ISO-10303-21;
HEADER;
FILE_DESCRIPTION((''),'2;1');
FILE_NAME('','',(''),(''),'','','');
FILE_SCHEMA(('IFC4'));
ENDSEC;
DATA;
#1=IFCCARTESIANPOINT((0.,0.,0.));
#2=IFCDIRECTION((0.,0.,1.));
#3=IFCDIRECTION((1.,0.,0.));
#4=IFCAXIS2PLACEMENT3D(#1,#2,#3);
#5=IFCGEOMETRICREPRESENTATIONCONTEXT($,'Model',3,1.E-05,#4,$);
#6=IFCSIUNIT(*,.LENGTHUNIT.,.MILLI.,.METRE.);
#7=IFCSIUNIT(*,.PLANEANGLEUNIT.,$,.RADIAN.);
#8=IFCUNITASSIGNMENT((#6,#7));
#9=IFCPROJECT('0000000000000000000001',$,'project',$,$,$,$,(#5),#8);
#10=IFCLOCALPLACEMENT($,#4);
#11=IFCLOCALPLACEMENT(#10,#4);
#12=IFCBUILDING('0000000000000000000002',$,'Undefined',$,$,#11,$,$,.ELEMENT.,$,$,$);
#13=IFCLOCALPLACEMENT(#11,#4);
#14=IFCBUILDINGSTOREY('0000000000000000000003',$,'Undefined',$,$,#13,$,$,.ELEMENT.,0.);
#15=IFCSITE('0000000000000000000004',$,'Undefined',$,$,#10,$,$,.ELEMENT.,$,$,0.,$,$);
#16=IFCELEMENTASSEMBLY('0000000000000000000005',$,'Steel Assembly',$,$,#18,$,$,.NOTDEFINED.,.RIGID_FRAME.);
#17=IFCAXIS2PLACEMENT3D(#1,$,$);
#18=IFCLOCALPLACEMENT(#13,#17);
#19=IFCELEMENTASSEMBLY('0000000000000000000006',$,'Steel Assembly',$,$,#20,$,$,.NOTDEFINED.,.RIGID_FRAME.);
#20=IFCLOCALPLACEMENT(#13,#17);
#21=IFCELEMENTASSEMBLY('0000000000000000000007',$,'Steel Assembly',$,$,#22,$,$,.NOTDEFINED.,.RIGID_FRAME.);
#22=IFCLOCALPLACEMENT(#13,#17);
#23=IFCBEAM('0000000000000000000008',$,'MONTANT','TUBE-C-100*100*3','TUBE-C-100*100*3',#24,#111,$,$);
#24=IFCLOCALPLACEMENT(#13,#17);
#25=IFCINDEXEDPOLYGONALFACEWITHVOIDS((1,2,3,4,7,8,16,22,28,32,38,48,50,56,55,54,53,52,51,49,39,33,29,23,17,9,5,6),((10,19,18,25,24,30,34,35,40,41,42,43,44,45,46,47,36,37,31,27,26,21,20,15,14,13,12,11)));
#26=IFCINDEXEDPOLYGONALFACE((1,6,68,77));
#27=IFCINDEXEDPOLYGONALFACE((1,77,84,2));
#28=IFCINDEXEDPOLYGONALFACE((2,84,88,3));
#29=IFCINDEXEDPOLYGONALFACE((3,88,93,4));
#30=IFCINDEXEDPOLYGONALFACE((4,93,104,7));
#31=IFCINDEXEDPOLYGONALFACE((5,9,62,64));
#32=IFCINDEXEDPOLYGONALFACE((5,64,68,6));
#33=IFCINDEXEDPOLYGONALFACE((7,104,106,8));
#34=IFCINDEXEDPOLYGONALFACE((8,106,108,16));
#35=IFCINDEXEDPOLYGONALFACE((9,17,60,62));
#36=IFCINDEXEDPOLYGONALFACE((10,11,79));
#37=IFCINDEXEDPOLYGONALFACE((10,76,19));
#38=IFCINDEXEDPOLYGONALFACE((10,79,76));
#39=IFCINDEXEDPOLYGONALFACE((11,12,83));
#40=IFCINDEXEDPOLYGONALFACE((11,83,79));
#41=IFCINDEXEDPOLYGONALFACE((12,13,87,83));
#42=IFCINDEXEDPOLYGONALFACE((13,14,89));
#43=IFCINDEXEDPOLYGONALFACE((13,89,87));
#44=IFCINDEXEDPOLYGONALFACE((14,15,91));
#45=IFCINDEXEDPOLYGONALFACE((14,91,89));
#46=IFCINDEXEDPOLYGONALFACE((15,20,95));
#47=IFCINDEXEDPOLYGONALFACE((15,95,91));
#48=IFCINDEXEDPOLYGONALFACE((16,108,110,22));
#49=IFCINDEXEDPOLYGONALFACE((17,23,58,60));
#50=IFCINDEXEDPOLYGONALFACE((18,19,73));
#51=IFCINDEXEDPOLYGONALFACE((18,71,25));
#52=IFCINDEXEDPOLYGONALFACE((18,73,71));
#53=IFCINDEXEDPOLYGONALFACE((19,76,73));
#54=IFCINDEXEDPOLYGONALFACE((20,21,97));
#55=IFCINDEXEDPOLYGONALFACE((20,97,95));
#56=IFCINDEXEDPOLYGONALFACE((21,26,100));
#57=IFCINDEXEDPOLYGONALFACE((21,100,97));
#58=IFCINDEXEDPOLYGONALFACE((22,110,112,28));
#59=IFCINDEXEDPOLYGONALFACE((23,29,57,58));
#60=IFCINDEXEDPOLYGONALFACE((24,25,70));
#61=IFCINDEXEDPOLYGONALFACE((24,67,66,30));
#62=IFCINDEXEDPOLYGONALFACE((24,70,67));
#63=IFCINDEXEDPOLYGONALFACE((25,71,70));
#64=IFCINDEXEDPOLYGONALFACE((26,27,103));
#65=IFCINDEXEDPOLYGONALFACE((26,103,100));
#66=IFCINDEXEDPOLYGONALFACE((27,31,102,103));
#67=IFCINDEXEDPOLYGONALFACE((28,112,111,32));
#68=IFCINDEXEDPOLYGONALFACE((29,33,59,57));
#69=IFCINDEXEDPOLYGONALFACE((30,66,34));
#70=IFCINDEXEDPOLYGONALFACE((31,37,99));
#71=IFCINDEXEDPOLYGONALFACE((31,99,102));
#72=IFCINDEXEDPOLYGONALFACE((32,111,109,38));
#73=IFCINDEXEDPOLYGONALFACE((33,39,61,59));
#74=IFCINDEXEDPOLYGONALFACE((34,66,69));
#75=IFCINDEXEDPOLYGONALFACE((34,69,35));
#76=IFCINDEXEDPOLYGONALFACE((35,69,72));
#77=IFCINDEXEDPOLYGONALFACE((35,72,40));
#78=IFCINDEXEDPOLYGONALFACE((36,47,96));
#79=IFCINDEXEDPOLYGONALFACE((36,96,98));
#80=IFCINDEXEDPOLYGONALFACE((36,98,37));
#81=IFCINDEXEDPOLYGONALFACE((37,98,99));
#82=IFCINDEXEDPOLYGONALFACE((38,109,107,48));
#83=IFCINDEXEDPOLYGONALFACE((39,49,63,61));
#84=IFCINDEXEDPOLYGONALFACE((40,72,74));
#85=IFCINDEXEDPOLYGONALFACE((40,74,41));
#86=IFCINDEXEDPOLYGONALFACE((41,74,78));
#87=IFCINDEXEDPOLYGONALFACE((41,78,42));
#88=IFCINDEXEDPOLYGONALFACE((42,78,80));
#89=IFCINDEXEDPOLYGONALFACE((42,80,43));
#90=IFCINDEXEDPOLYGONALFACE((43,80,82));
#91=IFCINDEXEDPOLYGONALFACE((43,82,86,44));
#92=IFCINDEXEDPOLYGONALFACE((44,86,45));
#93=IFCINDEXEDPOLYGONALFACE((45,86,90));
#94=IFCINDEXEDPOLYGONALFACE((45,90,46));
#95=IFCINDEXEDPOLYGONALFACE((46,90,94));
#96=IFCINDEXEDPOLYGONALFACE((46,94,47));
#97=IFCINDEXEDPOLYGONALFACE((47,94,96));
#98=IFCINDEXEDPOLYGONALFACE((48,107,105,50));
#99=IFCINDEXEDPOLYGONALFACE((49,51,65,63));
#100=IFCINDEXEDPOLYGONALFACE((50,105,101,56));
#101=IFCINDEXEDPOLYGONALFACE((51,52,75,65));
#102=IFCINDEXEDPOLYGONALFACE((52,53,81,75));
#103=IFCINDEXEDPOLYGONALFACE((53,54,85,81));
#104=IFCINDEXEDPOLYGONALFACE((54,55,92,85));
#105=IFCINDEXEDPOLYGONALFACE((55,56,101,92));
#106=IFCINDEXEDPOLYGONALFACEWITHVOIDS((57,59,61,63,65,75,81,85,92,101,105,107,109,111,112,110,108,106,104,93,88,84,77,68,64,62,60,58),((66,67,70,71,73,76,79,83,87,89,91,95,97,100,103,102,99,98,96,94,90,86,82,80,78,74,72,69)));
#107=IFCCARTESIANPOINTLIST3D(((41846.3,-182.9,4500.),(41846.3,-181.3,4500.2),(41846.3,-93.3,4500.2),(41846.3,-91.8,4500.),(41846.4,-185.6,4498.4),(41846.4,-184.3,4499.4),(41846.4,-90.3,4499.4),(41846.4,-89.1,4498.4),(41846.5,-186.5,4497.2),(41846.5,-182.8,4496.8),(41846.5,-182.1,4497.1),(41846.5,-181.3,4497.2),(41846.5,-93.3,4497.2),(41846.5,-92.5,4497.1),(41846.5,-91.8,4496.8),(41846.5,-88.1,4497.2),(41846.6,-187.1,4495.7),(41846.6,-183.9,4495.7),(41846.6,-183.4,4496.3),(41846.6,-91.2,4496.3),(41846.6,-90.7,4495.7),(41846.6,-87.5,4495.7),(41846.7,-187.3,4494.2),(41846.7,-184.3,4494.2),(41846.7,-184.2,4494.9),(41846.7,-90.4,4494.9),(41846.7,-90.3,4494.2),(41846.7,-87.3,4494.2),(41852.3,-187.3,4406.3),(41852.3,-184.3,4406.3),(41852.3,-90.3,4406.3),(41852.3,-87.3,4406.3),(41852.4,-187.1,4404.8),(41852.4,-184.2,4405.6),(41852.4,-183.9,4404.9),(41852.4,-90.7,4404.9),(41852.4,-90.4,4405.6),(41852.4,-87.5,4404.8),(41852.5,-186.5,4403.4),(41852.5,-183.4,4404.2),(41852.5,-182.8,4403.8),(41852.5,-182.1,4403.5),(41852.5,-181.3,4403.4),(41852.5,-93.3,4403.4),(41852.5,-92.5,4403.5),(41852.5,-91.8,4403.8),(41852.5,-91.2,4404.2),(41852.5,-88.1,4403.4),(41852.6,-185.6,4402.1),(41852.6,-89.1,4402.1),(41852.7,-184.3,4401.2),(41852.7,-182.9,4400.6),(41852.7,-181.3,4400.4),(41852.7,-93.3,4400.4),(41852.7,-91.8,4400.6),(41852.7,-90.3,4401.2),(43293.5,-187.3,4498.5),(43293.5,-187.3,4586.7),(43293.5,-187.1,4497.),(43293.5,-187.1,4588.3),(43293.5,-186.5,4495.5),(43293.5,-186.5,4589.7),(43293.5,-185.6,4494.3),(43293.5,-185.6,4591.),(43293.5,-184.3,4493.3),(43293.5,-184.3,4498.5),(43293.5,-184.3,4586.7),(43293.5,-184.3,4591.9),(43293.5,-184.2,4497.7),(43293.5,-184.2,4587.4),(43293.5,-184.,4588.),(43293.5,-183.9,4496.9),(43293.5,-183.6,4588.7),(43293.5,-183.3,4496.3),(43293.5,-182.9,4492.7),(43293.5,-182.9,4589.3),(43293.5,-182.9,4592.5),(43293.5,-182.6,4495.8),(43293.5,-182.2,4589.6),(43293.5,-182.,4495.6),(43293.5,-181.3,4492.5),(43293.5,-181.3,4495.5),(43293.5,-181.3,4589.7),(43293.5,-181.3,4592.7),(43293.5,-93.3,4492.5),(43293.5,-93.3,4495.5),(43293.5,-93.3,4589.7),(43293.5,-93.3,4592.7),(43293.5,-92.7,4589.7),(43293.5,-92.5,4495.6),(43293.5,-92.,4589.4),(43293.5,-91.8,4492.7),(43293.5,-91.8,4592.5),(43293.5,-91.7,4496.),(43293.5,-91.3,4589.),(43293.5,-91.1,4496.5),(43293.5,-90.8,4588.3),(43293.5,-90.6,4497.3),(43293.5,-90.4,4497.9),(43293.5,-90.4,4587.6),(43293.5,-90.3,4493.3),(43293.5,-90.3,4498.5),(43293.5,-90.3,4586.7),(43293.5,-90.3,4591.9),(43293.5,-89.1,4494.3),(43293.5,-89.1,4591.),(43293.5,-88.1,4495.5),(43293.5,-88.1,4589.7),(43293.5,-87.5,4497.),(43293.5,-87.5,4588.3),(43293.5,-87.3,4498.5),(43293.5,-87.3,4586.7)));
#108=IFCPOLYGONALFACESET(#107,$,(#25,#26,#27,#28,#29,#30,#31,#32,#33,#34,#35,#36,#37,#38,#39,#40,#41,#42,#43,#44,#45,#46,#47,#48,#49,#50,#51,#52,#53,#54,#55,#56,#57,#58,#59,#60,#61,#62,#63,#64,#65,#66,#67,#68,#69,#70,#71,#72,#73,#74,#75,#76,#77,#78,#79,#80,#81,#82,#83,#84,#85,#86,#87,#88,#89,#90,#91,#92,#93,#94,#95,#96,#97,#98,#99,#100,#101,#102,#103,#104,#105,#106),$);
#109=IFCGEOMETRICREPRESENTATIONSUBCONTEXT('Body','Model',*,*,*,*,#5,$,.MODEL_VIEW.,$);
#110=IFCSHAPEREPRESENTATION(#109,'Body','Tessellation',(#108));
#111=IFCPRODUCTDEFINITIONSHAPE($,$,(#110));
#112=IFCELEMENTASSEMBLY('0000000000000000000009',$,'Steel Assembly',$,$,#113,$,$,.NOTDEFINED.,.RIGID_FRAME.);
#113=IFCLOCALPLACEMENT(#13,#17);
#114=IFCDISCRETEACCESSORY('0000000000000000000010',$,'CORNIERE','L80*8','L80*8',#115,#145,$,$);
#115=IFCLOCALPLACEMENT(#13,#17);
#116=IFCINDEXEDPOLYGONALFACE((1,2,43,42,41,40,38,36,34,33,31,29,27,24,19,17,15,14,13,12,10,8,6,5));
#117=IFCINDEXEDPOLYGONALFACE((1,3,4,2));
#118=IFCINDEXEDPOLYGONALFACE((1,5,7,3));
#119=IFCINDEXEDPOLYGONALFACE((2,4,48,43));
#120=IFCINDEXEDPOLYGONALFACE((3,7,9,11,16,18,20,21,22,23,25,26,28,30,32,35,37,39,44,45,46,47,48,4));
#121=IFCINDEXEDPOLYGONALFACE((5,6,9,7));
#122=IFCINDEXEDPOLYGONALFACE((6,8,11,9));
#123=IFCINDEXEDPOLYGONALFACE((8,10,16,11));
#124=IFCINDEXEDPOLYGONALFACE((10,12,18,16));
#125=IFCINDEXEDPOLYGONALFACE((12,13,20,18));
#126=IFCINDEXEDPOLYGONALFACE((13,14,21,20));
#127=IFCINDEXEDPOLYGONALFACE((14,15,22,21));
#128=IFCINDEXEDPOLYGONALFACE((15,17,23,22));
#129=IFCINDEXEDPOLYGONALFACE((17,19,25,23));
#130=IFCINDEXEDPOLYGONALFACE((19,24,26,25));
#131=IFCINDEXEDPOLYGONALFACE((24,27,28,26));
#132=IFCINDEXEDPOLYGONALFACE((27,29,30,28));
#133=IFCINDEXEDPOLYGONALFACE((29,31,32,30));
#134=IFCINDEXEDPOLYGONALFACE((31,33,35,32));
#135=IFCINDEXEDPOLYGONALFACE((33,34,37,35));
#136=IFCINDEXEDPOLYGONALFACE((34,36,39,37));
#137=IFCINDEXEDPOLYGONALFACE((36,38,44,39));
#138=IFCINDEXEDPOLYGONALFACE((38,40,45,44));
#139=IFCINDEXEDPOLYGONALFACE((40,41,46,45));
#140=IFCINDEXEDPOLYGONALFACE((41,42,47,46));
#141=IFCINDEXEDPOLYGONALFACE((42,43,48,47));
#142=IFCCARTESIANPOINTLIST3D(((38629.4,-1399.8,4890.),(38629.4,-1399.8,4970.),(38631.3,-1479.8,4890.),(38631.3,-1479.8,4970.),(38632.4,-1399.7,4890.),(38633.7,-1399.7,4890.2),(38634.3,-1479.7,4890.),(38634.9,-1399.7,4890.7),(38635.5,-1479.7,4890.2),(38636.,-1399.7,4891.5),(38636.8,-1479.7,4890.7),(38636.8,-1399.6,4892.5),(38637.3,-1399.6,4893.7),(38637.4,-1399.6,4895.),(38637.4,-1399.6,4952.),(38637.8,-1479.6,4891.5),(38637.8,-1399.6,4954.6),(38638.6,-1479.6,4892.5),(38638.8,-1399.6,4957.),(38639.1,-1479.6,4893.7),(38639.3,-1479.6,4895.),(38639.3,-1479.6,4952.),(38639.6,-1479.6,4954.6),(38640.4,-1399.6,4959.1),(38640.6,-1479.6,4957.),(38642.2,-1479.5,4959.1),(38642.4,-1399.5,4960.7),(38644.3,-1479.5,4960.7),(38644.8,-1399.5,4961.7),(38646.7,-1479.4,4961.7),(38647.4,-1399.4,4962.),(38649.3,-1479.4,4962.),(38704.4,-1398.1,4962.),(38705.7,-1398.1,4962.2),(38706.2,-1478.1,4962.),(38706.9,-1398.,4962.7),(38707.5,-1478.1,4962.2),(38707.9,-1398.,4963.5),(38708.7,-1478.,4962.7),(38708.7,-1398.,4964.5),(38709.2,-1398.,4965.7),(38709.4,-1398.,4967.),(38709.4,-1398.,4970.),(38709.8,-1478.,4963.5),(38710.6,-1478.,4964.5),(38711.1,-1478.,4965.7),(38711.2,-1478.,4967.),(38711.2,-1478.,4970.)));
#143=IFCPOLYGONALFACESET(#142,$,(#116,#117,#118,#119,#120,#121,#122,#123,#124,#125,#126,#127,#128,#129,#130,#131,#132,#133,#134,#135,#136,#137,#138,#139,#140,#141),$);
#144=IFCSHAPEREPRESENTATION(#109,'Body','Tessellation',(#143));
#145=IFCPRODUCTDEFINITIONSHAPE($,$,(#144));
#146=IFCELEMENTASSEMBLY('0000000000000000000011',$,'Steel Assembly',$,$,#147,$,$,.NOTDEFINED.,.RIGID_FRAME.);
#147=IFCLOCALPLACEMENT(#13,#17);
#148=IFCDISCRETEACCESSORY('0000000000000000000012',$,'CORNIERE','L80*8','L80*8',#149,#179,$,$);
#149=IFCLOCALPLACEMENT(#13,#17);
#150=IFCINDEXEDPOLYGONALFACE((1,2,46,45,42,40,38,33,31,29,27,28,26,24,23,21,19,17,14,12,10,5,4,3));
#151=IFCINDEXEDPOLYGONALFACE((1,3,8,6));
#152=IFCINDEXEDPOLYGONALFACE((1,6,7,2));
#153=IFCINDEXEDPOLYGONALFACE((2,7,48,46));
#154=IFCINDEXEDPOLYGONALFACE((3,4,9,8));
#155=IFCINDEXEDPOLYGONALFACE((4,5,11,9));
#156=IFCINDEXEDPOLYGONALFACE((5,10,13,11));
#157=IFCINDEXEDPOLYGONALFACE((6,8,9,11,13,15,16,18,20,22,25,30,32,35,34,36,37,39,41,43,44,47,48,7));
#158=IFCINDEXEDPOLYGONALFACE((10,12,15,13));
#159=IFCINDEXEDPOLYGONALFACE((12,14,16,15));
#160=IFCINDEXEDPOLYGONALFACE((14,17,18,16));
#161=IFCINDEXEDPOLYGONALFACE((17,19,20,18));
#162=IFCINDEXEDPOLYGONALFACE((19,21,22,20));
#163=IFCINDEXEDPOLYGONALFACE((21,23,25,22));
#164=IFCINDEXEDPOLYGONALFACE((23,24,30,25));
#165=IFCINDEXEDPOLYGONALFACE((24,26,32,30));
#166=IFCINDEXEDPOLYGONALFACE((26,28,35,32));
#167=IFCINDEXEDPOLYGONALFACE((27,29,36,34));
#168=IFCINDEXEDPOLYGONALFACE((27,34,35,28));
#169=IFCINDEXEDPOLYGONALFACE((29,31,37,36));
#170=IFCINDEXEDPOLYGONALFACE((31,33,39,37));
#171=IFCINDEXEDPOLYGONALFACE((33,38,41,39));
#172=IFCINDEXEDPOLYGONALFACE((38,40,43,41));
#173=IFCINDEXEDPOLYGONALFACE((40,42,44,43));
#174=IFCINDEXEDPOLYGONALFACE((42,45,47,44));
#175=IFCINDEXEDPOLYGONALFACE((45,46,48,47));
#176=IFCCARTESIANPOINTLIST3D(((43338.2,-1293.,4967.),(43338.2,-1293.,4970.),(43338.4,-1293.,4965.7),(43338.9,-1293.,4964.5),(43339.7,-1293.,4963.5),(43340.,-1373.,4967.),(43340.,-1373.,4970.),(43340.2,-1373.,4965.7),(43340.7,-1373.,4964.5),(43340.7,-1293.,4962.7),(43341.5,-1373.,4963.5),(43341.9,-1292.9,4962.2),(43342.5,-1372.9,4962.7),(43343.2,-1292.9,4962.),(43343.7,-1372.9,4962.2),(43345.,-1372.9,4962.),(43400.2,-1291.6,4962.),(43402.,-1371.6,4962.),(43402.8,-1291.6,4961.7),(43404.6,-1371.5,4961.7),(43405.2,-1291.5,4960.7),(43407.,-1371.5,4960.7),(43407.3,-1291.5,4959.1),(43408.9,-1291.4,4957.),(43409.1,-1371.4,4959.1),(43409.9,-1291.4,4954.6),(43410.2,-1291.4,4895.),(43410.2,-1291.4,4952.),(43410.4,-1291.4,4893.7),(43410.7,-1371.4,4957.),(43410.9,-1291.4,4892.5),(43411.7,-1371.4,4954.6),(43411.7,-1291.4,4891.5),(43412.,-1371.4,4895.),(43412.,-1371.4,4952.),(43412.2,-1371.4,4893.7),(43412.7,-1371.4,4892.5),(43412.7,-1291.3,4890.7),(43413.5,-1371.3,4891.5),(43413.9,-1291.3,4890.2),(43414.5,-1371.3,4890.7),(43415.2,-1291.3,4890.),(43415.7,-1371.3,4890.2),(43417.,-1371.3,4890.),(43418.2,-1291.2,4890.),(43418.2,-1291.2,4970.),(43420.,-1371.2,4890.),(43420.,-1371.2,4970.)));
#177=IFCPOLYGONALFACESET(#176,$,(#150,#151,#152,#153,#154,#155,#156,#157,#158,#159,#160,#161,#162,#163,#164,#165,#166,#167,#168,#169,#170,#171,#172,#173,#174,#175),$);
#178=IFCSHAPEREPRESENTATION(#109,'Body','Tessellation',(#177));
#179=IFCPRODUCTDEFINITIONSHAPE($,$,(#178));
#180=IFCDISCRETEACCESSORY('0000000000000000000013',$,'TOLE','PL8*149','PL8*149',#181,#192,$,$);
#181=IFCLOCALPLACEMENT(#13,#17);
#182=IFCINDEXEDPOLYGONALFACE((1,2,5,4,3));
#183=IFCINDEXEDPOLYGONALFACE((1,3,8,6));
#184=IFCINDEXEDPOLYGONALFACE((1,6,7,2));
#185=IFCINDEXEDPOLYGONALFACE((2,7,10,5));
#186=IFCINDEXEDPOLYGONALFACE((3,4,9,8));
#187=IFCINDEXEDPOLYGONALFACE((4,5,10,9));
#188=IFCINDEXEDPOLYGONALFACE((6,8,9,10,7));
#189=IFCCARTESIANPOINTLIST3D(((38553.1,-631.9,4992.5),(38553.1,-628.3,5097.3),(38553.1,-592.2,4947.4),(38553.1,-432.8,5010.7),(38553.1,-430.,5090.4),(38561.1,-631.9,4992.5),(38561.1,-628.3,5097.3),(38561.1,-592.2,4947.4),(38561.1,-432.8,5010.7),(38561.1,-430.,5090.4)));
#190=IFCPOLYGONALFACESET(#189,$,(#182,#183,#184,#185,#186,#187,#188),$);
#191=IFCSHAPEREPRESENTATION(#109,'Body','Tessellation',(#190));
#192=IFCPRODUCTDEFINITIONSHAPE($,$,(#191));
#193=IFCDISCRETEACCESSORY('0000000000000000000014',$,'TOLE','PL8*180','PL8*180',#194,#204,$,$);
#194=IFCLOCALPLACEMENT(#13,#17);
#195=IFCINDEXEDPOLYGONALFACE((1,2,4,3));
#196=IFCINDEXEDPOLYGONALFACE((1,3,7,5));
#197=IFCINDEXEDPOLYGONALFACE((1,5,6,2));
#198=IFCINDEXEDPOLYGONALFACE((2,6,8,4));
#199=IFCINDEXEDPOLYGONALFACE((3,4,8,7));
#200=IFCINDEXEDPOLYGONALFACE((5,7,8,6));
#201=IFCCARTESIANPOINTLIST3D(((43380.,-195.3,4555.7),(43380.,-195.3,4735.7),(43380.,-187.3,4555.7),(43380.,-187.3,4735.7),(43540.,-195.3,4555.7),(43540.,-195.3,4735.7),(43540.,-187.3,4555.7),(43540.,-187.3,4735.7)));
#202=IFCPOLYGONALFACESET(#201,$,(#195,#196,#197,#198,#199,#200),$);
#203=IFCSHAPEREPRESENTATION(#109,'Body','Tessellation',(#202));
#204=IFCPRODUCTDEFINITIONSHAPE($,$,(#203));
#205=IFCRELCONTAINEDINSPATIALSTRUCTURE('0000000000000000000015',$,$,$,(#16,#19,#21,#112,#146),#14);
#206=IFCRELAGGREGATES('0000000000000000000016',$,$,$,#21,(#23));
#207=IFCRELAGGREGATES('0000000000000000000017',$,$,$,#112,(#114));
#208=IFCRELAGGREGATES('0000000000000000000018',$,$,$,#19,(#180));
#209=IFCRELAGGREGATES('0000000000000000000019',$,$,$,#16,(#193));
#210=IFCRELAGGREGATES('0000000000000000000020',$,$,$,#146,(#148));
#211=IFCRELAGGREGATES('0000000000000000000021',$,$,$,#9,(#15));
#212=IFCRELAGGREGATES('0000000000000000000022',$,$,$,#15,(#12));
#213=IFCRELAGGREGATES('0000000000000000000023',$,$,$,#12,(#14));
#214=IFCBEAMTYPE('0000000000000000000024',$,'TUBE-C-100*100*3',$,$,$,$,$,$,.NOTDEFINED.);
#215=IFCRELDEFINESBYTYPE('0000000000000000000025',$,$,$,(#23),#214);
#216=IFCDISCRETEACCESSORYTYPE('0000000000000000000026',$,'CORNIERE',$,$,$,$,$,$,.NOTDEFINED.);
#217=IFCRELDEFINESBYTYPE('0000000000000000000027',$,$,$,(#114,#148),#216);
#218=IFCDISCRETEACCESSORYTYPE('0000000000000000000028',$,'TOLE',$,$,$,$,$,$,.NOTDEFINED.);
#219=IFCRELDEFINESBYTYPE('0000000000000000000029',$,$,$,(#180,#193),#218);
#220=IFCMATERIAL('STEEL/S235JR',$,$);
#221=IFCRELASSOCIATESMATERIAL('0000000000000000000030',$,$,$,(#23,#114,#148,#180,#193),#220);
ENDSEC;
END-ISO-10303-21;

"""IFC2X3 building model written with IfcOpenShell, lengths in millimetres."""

from ifc_helpers import new_model, si_unit, frame, origin_with_axes, origin_2d_with_axis, place, context, subcontext, project, spatial, polyline, hollow_rectangle, l_section, outline, extrude, clip, halfspace, material, type_object, element, aggregate, save


model = new_model("IFC2X3")

# Units and contexts
model_context = context("Model", 3, precision=1e-05, world=origin_with_axes())
body_context = subcontext(model_context, "Body", "Model", "MODEL_VIEW")
ifc_project = project(units=[si_unit("LENGTHUNIT", "METRE", prefix="MILLI"), si_unit("PLANEANGLEUNIT", "RADIAN")], contexts=[model_context])

# Site, building, storey
site_placement = place(None, origin_with_axes())
site = spatial("IfcSite", under=ifc_project, at=site_placement, Name="Undefined", CompositionType="ELEMENT", RefElevation=0.0)
building_placement = place(site_placement, origin_with_axes())
building = spatial("IfcBuilding", under=site, at=building_placement, Name="Undefined", CompositionType="ELEMENT")
storey_placement = place(building_placement, origin_with_axes())
storey = spatial("IfcBuildingStorey", under=building, at=storey_placement, Name="Undefined", CompositionType="ELEMENT", Elevation=0.0)

# Element assemblies, beam
ifc_material_1 = material(Name="STEEL/S235JR")
assembly_1_placement = place(storey_placement, origin_with_axes())
assembly_1 = element("IfcElementAssembly", 1, at=assembly_1_placement, inside=storey, Name="Steel Assembly", AssemblyPlace="NOTDEFINED", PredefinedType="RIGID_FRAME")
assembly_2_placement = place(storey_placement, origin_with_axes())
assembly_2 = element("IfcElementAssembly", 2, at=assembly_2_placement, inside=storey, Name="Steel Assembly", AssemblyPlace="NOTDEFINED", PredefinedType="RIGID_FRAME")
assembly_3_placement = place(storey_placement, origin_with_axes())
assembly_3 = element("IfcElementAssembly", 3, at=assembly_3_placement, inside=storey, Name="Steel Assembly", AssemblyPlace="NOTDEFINED", PredefinedType="RIGID_FRAME")
beam_type_1 = type_object("IfcBeamType", Name="TUBE-C-100*100*3", PredefinedType="NOTDEFINED")
beam_1_placement = place(assembly_3_placement, frame((43296.8, -137.3, 4542.8), z_axis=(-0.063838, 0.0, 0.99796), x_axis=(-0.99796, 0.0, -0.063838)))
beam_1 = element("IfcBeam", 4, at=beam_1_placement, type_object=beam_type_1, material=ifc_material_1, Name="MONTANT", Description="TUBE-C-100*100*3", ObjectType="TUBE-C-100*100*3", context=body_context, shape_type="Clipping", body=[
    clip(clip(extrude(hollow_rectangle(XDim=100.0, YDim=100.0, WallThickness=3.0, InnerFilletRadius=3.0, OuterFilletRadius=6.0, at=origin_2d_with_axis()), frame((1450.3, 0.0, 0.0), z_axis=(-1.0, 0.0, 0.0), x_axis=(0.0, -1.0, 0.0)), (0.0, 0.0, 1.0), 1450.3), halfspace(frame((6.5, 50.0, -50.0), z_axis=(-0.99796, -0.000001, -0.063838), x_axis=(-0.063838, 0.0, 0.99796)), False)), halfspace(frame((1450.3, 1000.0, 0.0), z_axis=(-1.0, 0.0, 0.0), x_axis=(0.0, 0.0, 1.0)), True)),
])

# Element assemblies, discrete accessories
assembly_4_placement = place(storey_placement, origin_with_axes())
assembly_4 = element("IfcElementAssembly", 5, at=assembly_4_placement, inside=storey, Name="Steel Assembly", AssemblyPlace="NOTDEFINED", PredefinedType="RIGID_FRAME")
discrete_accessory_type_1 = type_object("IfcDiscreteAccessoryType", Name="CORNIERE")
discrete_accessory_1_placement = place(assembly_4_placement, frame((38669.4, -1398.9, 4930.0), z_axis=(0.0, 0.0, -1.0), x_axis=(0.022754, -0.999741, 0.000001)))
discrete_accessory_1 = element("IfcDiscreteAccessory", 6, at=discrete_accessory_1_placement, type_object=discrete_accessory_type_1, material=ifc_material_1, Name="CORNIERE", Description="L80*8", ObjectType="L80*8", context=body_context, shape_type="SweptSolid", body=[
    extrude(l_section(Depth=80.0, Width=80.0, Thickness=8.0, FilletRadius=10.0, EdgeRadius=5.0, at=origin_2d_with_axis()), frame((80.0, 0.0, 0.0), z_axis=(-1.0, 0.0, 0.0), x_axis=(0.0, -1.0, 0.0)), (0.0, 0.0, 1.0), 80.0),
])
assembly_5_placement = place(storey_placement, origin_with_axes())
assembly_5 = element("IfcElementAssembly", 7, at=assembly_5_placement, inside=storey, Name="Steel Assembly", AssemblyPlace="NOTDEFINED", PredefinedType="RIGID_FRAME")
discrete_accessory_2_placement = place(assembly_5_placement, frame((43380.0, -1372.1, 4930.0), z_axis=(0.0, 0.0, -1.0), x_axis=(-0.022588, 0.999745, -0.000001)))
discrete_accessory_2 = element("IfcDiscreteAccessory", 8, at=discrete_accessory_2_placement, type_object=discrete_accessory_type_1, material=ifc_material_1, Name="CORNIERE", Description="L80*8", ObjectType="L80*8", context=body_context, shape_type="SweptSolid", body=[
    extrude(l_section(Depth=80.0, Width=80.0, Thickness=8.0, FilletRadius=10.0, EdgeRadius=5.0, at=origin_2d_with_axis()), frame((80.0, 0.0, 0.0), z_axis=(-1.0, 0.0, 0.0), x_axis=(0.0, -1.0, 0.0)), (0.0, 0.0, 1.0), 80.0),
])

# Discrete accessories
discrete_accessory_type_2 = type_object("IfcDiscreteAccessoryType", Name="TOLE")
discrete_accessory_3_placement = place(assembly_2_placement, frame((38557.1, -430.0, 5090.4), z_axis=(1.0, 0.000006, 0.000168), x_axis=(0.0, -0.999388, 0.03498)))
discrete_accessory_3 = element("IfcDiscreteAccessory", 9, at=discrete_accessory_3_placement, type_object=discrete_accessory_type_2, material=ifc_material_1, Name="TOLE", Description="PL8*149", ObjectType="PL8*149", context=body_context, shape_type="SweptSolid", body=[
    extrude(outline(polyline([(0.0, 0.0), (198.3, 0.0), (198.3, 104.9), (157.0, 148.5), (0.0, 79.8), (0.0, 0.0)])), frame((0.0, 0.0, -4.0), z_axis=(0.0, 0.0, 1.0), x_axis=(1.0, 0.0, 0.0)), (0.0, 0.0, 1.0), 8.0),
])
discrete_accessory_4_placement = place(assembly_1_placement, frame((43380.0, -191.3, 4645.7), z_axis=(0.0, -1.0, 0.0), x_axis=(1.0, 0.0, 0.0)))
discrete_accessory_4 = element("IfcDiscreteAccessory", 10, at=discrete_accessory_4_placement, type_object=discrete_accessory_type_2, material=ifc_material_1, Name="TOLE", Description="PL8*180", ObjectType="PL8*180", context=body_context, shape_type="SweptSolid", body=[
    extrude(outline(polyline([(0.0, 90.0), (160.0, 90.0), (160.0, -90.0), (0.0, -90.0), (0.0, 90.0)])), frame((0.0, 0.0, -4.0), z_axis=(0.0, 0.0, 1.0), x_axis=(1.0, 0.0, 0.0)), (0.0, 0.0, 1.0), 8.0),
])

aggregate(assembly_3, [beam_1])

aggregate(assembly_4, [discrete_accessory_1])

aggregate(assembly_2, [discrete_accessory_3])

aggregate(assembly_1, [discrete_accessory_4])
aggregate(assembly_5, [discrete_accessory_2])

save(model, "model.ifc")
